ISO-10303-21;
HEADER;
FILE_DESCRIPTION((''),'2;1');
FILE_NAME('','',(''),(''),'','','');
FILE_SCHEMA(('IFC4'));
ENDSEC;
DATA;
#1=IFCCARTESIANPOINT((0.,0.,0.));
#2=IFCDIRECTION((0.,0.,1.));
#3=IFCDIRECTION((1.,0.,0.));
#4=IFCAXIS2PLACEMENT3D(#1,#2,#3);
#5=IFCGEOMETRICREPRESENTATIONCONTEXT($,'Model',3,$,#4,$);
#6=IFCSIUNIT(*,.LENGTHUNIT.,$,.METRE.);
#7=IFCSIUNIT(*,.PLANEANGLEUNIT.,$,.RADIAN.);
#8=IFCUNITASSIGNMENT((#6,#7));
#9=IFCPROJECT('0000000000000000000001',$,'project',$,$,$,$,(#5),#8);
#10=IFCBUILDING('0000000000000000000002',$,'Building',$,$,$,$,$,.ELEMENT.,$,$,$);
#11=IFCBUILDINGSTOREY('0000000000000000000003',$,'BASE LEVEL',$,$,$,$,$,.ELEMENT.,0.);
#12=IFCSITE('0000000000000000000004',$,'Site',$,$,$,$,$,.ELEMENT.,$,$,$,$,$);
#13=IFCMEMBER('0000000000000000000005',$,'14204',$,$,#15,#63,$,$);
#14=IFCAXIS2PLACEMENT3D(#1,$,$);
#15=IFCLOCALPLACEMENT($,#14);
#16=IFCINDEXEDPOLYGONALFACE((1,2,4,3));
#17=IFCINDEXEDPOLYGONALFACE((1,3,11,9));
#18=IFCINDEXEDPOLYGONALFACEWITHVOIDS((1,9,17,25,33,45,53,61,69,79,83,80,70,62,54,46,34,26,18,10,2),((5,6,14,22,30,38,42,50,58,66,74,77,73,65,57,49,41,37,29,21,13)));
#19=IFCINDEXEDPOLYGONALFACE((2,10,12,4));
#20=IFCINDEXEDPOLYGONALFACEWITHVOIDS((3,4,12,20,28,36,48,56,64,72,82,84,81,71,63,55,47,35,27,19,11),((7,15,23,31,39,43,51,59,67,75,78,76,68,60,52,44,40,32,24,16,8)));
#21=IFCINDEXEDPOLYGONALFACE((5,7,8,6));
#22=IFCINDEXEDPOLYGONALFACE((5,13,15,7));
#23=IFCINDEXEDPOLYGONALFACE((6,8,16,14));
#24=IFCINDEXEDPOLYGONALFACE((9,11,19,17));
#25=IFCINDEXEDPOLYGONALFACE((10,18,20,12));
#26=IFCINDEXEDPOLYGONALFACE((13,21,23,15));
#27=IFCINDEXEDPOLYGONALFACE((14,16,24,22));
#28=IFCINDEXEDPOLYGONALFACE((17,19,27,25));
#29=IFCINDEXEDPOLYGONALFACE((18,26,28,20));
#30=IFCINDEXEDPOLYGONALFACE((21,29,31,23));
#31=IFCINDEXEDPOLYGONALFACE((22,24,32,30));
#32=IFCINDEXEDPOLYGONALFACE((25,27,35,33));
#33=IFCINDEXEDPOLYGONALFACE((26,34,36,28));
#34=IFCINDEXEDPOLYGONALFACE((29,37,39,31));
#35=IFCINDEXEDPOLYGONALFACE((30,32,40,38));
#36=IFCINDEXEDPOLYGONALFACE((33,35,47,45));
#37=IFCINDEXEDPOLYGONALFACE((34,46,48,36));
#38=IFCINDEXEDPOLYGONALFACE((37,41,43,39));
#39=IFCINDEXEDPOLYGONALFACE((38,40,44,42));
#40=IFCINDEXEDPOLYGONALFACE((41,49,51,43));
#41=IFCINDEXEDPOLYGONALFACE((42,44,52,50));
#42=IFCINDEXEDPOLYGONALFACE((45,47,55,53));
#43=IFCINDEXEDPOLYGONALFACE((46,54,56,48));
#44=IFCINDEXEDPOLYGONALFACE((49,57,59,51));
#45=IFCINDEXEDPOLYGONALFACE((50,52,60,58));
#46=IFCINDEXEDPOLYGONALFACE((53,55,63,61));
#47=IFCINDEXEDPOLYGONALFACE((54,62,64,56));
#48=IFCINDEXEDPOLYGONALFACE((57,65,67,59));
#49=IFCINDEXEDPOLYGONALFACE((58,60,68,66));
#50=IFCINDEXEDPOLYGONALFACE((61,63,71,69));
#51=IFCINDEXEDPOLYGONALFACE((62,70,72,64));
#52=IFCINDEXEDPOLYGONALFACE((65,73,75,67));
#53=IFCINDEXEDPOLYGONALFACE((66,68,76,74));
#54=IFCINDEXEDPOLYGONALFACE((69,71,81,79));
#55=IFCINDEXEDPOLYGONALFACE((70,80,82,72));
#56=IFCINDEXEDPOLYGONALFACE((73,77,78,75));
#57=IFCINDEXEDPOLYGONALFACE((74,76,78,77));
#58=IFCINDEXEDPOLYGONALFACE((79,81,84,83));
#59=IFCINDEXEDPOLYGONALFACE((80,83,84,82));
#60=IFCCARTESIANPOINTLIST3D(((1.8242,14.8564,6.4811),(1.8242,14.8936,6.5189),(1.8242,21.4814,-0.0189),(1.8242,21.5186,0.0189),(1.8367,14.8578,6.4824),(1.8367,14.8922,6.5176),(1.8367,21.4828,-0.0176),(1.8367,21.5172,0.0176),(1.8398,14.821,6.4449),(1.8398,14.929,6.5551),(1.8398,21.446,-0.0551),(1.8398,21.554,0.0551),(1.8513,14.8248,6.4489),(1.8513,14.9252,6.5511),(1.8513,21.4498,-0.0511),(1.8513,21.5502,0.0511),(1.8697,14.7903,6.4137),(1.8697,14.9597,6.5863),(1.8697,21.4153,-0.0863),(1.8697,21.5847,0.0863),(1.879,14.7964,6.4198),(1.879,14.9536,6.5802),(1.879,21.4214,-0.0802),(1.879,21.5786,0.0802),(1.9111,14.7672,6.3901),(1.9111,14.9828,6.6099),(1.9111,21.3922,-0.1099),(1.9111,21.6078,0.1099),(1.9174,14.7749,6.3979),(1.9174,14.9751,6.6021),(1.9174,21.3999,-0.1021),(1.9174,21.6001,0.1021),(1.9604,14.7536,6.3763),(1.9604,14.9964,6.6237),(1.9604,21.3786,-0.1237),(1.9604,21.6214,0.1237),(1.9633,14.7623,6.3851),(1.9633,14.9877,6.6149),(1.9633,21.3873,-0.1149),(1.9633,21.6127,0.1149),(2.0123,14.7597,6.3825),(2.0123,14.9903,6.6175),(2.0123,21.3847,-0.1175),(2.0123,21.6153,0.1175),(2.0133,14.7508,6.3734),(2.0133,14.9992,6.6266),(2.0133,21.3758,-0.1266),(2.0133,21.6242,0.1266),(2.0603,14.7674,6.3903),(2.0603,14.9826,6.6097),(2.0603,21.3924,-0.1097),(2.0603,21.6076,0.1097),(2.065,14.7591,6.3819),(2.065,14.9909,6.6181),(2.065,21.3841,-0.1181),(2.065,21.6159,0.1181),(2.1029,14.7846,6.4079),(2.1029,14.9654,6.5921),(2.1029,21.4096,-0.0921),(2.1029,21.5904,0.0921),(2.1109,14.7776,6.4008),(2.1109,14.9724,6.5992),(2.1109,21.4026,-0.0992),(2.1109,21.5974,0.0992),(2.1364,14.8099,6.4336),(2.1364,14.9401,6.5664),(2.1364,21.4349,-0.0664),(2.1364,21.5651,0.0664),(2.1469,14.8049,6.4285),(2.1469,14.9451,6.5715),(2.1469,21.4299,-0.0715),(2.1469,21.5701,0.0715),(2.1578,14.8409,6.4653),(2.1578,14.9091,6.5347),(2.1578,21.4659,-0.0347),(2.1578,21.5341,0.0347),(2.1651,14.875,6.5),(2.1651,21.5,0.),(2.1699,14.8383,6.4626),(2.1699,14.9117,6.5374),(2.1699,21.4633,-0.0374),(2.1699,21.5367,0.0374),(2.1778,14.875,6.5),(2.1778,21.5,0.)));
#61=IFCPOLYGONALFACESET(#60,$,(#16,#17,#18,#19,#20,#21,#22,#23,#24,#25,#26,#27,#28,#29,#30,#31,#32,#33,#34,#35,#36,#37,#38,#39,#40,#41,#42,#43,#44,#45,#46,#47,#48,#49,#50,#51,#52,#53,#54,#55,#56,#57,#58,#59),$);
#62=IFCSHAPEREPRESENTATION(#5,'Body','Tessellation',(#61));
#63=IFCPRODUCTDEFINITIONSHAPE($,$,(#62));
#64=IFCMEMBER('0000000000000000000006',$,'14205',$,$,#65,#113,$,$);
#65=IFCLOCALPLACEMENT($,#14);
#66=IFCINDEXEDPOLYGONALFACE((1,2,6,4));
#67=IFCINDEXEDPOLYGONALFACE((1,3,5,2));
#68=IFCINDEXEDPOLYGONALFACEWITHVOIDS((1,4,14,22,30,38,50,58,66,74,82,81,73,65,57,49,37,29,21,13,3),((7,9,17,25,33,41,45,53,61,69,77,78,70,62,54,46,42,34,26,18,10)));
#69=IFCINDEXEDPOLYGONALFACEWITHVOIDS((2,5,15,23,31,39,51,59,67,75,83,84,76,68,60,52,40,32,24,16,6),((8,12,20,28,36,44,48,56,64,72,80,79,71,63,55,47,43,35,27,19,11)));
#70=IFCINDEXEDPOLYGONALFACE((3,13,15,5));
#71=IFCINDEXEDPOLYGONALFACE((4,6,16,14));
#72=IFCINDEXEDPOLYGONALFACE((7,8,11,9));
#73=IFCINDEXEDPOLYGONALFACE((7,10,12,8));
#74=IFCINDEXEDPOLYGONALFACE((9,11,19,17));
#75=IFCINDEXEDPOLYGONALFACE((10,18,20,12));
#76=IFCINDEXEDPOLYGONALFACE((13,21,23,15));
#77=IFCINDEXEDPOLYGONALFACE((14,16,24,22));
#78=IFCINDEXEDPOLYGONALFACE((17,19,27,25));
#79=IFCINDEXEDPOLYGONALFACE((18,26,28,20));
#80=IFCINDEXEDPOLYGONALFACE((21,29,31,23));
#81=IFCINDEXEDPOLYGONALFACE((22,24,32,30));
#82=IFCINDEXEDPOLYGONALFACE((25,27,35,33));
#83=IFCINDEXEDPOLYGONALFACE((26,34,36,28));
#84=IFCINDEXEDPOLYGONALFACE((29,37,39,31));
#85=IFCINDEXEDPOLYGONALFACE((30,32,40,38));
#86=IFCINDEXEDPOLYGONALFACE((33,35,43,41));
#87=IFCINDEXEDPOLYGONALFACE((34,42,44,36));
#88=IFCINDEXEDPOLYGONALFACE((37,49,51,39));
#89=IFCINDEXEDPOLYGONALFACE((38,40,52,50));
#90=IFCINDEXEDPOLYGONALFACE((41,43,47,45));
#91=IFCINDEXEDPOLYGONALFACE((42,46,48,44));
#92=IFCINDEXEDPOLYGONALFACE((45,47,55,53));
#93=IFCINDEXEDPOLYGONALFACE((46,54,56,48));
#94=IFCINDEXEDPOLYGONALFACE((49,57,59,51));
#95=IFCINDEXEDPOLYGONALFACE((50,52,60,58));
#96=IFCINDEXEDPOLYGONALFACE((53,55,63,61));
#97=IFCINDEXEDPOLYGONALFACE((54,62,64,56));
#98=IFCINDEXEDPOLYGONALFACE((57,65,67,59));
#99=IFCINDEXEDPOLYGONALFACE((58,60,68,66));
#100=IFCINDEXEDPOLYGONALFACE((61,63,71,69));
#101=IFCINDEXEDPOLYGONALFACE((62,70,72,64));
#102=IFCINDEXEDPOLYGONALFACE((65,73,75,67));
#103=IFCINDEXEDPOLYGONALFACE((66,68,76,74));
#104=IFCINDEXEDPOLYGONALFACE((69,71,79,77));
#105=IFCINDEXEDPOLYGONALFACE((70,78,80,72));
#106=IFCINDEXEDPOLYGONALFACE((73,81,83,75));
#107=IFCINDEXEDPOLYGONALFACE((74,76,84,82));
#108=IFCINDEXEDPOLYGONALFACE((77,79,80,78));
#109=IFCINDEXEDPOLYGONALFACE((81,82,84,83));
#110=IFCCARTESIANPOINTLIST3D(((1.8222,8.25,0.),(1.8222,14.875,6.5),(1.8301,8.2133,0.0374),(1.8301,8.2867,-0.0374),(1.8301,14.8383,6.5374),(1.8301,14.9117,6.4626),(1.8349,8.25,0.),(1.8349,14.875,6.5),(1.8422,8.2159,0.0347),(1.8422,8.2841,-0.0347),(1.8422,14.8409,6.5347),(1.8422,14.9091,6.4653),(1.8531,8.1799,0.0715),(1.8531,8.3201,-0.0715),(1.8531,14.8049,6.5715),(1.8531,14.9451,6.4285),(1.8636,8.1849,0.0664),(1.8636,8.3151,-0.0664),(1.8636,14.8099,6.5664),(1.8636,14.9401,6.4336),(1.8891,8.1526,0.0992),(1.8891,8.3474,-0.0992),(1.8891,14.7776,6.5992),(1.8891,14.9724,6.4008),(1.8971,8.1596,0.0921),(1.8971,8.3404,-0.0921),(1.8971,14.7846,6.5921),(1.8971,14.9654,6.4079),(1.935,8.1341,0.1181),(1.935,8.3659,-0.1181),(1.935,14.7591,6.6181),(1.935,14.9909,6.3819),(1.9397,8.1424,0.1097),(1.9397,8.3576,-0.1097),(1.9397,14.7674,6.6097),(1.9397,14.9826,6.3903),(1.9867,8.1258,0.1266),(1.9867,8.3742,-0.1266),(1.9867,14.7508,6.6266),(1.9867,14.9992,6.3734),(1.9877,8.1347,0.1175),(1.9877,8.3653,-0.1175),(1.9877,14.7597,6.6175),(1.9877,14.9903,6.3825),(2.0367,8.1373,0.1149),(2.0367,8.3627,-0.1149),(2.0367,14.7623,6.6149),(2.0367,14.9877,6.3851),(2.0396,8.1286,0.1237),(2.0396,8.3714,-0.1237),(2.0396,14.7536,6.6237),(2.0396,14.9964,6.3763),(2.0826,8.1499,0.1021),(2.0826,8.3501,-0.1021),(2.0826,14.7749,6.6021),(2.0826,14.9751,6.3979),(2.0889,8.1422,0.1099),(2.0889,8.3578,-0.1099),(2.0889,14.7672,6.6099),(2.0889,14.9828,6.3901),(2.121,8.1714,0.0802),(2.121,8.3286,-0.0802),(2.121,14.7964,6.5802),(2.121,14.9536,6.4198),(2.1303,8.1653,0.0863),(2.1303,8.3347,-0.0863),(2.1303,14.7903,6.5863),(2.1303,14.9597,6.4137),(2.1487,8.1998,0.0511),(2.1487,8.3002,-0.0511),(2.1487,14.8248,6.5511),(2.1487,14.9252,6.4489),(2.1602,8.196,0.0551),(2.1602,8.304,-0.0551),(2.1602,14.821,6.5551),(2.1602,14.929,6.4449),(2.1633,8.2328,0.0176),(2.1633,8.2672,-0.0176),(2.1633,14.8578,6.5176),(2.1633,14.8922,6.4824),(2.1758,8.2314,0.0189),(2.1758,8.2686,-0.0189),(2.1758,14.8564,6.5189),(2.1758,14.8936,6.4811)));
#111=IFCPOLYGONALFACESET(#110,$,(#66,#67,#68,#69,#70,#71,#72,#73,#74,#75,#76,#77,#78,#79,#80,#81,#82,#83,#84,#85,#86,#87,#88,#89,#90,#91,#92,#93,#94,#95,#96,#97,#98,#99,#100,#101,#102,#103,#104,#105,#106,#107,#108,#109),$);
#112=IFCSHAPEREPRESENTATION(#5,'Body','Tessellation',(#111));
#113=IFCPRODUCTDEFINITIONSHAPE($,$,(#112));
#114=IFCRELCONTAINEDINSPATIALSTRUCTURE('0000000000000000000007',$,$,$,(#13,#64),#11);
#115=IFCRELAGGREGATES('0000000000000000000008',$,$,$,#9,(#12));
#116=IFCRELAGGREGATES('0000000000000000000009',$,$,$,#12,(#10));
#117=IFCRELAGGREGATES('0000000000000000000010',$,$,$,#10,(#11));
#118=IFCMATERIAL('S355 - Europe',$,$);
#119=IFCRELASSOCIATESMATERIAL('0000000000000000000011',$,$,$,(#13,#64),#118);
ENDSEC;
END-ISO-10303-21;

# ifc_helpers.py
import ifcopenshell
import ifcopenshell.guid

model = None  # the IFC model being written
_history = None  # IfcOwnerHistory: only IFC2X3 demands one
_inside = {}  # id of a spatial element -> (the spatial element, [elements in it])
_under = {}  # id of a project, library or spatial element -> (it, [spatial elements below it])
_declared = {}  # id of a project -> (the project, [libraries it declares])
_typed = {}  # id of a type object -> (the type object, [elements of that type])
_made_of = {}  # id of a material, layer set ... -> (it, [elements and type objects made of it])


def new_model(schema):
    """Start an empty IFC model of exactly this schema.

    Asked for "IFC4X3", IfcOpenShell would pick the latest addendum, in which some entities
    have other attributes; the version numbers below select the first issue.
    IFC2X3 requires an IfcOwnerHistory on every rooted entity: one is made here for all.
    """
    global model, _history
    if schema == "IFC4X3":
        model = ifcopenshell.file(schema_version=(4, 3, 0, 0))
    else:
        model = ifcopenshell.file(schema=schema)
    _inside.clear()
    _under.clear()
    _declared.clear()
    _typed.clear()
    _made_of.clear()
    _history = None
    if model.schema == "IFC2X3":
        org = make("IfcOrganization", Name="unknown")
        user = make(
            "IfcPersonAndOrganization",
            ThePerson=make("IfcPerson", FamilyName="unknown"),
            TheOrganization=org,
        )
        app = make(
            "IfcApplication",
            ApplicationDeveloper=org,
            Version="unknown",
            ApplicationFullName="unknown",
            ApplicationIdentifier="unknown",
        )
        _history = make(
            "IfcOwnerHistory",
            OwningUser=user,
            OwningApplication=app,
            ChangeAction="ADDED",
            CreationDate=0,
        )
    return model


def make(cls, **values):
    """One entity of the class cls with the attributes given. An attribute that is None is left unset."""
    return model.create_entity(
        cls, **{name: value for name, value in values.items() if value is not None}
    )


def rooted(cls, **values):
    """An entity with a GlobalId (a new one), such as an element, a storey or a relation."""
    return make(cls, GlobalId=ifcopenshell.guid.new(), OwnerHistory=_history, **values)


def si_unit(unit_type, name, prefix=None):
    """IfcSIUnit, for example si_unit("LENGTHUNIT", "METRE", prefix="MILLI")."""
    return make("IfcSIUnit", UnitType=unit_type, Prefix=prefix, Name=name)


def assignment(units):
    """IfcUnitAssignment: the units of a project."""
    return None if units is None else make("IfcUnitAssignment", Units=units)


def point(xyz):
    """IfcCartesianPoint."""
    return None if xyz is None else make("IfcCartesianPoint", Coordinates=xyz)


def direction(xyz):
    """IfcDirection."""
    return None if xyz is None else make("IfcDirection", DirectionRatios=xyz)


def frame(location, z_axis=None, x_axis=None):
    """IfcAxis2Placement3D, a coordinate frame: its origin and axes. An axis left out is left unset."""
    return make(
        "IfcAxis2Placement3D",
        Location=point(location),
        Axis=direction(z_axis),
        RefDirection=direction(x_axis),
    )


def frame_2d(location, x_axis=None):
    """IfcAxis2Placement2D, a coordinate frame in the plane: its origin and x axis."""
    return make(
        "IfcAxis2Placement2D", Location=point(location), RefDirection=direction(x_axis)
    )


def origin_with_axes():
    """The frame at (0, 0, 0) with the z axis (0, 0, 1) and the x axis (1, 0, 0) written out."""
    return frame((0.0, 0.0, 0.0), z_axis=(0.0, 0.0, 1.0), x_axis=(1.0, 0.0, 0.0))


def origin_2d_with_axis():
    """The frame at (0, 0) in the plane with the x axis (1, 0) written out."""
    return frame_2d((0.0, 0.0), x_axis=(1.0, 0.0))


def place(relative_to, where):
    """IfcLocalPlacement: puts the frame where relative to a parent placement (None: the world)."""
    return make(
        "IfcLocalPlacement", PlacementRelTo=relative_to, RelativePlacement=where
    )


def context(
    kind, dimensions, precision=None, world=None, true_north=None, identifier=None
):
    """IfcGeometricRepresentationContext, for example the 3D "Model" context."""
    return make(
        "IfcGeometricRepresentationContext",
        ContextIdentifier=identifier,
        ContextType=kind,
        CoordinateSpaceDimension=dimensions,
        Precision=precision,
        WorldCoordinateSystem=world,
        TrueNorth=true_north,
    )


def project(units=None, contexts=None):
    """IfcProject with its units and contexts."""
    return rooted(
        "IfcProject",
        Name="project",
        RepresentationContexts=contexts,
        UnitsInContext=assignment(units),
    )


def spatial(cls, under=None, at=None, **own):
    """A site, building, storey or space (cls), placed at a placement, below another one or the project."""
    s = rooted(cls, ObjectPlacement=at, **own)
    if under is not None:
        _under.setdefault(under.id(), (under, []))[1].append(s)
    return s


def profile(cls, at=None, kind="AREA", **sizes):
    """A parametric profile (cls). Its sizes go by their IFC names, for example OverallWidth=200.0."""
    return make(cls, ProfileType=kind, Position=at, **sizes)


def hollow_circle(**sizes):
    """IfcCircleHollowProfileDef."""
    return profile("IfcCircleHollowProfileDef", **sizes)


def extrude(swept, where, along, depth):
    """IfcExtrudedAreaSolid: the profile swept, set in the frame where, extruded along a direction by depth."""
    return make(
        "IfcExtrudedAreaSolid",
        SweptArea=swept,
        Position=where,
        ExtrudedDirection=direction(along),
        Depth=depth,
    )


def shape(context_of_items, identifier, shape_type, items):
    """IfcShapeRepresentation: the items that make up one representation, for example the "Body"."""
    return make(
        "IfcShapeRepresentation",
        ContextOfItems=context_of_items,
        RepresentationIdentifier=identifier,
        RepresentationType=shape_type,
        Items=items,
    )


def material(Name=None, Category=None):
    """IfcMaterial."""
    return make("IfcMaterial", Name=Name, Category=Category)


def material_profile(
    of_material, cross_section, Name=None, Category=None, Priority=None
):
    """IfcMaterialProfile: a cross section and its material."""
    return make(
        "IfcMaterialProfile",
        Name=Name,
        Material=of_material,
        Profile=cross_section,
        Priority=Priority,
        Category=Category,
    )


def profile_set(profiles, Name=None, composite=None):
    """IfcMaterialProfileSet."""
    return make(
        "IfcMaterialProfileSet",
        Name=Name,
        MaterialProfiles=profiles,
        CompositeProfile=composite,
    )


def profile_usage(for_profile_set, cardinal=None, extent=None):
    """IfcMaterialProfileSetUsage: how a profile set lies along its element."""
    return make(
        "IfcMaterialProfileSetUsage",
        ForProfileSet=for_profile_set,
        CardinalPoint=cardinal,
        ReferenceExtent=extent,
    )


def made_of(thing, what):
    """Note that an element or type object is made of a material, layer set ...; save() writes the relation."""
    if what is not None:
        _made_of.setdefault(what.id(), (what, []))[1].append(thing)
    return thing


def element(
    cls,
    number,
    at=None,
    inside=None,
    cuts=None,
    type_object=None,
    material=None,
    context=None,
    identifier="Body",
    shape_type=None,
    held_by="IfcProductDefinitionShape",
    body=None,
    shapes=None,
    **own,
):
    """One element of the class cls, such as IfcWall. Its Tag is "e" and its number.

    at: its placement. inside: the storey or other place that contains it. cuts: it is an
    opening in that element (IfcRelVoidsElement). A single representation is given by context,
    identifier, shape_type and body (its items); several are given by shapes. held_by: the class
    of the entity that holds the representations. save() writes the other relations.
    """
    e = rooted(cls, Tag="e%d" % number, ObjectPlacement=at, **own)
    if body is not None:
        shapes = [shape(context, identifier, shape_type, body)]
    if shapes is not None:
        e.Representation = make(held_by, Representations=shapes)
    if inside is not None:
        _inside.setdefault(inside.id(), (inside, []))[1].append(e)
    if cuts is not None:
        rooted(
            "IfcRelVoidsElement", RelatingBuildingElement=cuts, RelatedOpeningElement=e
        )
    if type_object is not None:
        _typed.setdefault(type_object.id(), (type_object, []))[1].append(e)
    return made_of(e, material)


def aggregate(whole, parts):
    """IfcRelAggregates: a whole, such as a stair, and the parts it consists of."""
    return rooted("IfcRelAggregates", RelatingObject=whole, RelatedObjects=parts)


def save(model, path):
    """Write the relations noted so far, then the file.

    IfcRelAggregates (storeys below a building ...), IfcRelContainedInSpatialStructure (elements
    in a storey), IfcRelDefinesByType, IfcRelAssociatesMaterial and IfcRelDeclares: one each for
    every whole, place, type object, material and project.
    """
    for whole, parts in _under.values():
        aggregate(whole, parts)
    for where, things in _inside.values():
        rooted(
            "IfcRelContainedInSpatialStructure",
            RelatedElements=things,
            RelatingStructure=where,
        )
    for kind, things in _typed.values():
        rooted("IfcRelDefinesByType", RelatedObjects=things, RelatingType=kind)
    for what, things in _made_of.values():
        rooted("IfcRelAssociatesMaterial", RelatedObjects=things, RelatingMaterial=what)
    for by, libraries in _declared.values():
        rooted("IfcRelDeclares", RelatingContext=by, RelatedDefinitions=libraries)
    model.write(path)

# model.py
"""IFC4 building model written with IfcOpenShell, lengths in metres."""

from ifc_helpers import new_model, si_unit, frame, origin_with_axes, origin_2d_with_axis, place, context, project, spatial, hollow_circle, extrude, material, material_profile, profile_set, profile_usage, element, save


model = new_model("IFC4")

# Units and contexts
model_context = context("Model", 3, world=origin_with_axes())
ifc_project = project(units=[si_unit("LENGTHUNIT", "METRE"), si_unit("PLANEANGLEUNIT", "RADIAN")], contexts=[model_context])

# Site, building, storey
site = spatial("IfcSite", under=ifc_project, Name="Site", CompositionType="ELEMENT")
building = spatial("IfcBuilding", under=site, Name="Building", CompositionType="ELEMENT")
storey = spatial("IfcBuildingStorey", under=building, Name="BASE LEVEL", CompositionType="ELEMENT", Elevation=0.0)

# Shared definitions
ifc_material = material(Name="S355 - Europe")

# Members
ifc_material_profile_1 = material_profile(ifc_material, hollow_circle(Radius=0.1778, WallThickness=0.0127, at=origin_2d_with_axis()))
ifc_profile_set_1 = profile_set([ifc_material_profile_1])
ifc_profile_usage_1 = profile_usage(ifc_profile_set_1, cardinal=10)
member_1_placement = place(None, frame((2.0, 21.5, 0.0), z_axis=(0.0, -0.713809, 0.700341), x_axis=(1.0, 0.0, 0.0)))
element("IfcMember", 1, at=member_1_placement, inside=storey, material=ifc_profile_usage_1, Name="14204", context=model_context, shape_type="SweptSolid", body=[
    extrude(hollow_circle(Radius=0.1778, WallThickness=0.0127, at=origin_2d_with_axis()), origin_with_axes(), (0.0, 0.0, 1.0), 9.2812),
])
ifc_material_profile_2 = material_profile(ifc_material, hollow_circle(Radius=0.1778, WallThickness=0.0127, at=origin_2d_with_axis()))
ifc_profile_set_2 = profile_set([ifc_material_profile_2])
ifc_profile_usage_2 = profile_usage(ifc_profile_set_2, cardinal=10)
member_2_placement = place(None, frame((2.0, 8.25, 0.0), z_axis=(0.0, 0.713809, 0.700341), x_axis=(-1.0, 0.0, 0.0)))
element("IfcMember", 2, at=member_2_placement, inside=storey, material=ifc_profile_usage_2, Name="14205", context=model_context, shape_type="SweptSolid", body=[
    extrude(hollow_circle(Radius=0.1778, WallThickness=0.0127, at=origin_2d_with_axis()), origin_with_axes(), (0.0, 0.0, 1.0), 9.2812),
])

save(model, "model.ifc")
